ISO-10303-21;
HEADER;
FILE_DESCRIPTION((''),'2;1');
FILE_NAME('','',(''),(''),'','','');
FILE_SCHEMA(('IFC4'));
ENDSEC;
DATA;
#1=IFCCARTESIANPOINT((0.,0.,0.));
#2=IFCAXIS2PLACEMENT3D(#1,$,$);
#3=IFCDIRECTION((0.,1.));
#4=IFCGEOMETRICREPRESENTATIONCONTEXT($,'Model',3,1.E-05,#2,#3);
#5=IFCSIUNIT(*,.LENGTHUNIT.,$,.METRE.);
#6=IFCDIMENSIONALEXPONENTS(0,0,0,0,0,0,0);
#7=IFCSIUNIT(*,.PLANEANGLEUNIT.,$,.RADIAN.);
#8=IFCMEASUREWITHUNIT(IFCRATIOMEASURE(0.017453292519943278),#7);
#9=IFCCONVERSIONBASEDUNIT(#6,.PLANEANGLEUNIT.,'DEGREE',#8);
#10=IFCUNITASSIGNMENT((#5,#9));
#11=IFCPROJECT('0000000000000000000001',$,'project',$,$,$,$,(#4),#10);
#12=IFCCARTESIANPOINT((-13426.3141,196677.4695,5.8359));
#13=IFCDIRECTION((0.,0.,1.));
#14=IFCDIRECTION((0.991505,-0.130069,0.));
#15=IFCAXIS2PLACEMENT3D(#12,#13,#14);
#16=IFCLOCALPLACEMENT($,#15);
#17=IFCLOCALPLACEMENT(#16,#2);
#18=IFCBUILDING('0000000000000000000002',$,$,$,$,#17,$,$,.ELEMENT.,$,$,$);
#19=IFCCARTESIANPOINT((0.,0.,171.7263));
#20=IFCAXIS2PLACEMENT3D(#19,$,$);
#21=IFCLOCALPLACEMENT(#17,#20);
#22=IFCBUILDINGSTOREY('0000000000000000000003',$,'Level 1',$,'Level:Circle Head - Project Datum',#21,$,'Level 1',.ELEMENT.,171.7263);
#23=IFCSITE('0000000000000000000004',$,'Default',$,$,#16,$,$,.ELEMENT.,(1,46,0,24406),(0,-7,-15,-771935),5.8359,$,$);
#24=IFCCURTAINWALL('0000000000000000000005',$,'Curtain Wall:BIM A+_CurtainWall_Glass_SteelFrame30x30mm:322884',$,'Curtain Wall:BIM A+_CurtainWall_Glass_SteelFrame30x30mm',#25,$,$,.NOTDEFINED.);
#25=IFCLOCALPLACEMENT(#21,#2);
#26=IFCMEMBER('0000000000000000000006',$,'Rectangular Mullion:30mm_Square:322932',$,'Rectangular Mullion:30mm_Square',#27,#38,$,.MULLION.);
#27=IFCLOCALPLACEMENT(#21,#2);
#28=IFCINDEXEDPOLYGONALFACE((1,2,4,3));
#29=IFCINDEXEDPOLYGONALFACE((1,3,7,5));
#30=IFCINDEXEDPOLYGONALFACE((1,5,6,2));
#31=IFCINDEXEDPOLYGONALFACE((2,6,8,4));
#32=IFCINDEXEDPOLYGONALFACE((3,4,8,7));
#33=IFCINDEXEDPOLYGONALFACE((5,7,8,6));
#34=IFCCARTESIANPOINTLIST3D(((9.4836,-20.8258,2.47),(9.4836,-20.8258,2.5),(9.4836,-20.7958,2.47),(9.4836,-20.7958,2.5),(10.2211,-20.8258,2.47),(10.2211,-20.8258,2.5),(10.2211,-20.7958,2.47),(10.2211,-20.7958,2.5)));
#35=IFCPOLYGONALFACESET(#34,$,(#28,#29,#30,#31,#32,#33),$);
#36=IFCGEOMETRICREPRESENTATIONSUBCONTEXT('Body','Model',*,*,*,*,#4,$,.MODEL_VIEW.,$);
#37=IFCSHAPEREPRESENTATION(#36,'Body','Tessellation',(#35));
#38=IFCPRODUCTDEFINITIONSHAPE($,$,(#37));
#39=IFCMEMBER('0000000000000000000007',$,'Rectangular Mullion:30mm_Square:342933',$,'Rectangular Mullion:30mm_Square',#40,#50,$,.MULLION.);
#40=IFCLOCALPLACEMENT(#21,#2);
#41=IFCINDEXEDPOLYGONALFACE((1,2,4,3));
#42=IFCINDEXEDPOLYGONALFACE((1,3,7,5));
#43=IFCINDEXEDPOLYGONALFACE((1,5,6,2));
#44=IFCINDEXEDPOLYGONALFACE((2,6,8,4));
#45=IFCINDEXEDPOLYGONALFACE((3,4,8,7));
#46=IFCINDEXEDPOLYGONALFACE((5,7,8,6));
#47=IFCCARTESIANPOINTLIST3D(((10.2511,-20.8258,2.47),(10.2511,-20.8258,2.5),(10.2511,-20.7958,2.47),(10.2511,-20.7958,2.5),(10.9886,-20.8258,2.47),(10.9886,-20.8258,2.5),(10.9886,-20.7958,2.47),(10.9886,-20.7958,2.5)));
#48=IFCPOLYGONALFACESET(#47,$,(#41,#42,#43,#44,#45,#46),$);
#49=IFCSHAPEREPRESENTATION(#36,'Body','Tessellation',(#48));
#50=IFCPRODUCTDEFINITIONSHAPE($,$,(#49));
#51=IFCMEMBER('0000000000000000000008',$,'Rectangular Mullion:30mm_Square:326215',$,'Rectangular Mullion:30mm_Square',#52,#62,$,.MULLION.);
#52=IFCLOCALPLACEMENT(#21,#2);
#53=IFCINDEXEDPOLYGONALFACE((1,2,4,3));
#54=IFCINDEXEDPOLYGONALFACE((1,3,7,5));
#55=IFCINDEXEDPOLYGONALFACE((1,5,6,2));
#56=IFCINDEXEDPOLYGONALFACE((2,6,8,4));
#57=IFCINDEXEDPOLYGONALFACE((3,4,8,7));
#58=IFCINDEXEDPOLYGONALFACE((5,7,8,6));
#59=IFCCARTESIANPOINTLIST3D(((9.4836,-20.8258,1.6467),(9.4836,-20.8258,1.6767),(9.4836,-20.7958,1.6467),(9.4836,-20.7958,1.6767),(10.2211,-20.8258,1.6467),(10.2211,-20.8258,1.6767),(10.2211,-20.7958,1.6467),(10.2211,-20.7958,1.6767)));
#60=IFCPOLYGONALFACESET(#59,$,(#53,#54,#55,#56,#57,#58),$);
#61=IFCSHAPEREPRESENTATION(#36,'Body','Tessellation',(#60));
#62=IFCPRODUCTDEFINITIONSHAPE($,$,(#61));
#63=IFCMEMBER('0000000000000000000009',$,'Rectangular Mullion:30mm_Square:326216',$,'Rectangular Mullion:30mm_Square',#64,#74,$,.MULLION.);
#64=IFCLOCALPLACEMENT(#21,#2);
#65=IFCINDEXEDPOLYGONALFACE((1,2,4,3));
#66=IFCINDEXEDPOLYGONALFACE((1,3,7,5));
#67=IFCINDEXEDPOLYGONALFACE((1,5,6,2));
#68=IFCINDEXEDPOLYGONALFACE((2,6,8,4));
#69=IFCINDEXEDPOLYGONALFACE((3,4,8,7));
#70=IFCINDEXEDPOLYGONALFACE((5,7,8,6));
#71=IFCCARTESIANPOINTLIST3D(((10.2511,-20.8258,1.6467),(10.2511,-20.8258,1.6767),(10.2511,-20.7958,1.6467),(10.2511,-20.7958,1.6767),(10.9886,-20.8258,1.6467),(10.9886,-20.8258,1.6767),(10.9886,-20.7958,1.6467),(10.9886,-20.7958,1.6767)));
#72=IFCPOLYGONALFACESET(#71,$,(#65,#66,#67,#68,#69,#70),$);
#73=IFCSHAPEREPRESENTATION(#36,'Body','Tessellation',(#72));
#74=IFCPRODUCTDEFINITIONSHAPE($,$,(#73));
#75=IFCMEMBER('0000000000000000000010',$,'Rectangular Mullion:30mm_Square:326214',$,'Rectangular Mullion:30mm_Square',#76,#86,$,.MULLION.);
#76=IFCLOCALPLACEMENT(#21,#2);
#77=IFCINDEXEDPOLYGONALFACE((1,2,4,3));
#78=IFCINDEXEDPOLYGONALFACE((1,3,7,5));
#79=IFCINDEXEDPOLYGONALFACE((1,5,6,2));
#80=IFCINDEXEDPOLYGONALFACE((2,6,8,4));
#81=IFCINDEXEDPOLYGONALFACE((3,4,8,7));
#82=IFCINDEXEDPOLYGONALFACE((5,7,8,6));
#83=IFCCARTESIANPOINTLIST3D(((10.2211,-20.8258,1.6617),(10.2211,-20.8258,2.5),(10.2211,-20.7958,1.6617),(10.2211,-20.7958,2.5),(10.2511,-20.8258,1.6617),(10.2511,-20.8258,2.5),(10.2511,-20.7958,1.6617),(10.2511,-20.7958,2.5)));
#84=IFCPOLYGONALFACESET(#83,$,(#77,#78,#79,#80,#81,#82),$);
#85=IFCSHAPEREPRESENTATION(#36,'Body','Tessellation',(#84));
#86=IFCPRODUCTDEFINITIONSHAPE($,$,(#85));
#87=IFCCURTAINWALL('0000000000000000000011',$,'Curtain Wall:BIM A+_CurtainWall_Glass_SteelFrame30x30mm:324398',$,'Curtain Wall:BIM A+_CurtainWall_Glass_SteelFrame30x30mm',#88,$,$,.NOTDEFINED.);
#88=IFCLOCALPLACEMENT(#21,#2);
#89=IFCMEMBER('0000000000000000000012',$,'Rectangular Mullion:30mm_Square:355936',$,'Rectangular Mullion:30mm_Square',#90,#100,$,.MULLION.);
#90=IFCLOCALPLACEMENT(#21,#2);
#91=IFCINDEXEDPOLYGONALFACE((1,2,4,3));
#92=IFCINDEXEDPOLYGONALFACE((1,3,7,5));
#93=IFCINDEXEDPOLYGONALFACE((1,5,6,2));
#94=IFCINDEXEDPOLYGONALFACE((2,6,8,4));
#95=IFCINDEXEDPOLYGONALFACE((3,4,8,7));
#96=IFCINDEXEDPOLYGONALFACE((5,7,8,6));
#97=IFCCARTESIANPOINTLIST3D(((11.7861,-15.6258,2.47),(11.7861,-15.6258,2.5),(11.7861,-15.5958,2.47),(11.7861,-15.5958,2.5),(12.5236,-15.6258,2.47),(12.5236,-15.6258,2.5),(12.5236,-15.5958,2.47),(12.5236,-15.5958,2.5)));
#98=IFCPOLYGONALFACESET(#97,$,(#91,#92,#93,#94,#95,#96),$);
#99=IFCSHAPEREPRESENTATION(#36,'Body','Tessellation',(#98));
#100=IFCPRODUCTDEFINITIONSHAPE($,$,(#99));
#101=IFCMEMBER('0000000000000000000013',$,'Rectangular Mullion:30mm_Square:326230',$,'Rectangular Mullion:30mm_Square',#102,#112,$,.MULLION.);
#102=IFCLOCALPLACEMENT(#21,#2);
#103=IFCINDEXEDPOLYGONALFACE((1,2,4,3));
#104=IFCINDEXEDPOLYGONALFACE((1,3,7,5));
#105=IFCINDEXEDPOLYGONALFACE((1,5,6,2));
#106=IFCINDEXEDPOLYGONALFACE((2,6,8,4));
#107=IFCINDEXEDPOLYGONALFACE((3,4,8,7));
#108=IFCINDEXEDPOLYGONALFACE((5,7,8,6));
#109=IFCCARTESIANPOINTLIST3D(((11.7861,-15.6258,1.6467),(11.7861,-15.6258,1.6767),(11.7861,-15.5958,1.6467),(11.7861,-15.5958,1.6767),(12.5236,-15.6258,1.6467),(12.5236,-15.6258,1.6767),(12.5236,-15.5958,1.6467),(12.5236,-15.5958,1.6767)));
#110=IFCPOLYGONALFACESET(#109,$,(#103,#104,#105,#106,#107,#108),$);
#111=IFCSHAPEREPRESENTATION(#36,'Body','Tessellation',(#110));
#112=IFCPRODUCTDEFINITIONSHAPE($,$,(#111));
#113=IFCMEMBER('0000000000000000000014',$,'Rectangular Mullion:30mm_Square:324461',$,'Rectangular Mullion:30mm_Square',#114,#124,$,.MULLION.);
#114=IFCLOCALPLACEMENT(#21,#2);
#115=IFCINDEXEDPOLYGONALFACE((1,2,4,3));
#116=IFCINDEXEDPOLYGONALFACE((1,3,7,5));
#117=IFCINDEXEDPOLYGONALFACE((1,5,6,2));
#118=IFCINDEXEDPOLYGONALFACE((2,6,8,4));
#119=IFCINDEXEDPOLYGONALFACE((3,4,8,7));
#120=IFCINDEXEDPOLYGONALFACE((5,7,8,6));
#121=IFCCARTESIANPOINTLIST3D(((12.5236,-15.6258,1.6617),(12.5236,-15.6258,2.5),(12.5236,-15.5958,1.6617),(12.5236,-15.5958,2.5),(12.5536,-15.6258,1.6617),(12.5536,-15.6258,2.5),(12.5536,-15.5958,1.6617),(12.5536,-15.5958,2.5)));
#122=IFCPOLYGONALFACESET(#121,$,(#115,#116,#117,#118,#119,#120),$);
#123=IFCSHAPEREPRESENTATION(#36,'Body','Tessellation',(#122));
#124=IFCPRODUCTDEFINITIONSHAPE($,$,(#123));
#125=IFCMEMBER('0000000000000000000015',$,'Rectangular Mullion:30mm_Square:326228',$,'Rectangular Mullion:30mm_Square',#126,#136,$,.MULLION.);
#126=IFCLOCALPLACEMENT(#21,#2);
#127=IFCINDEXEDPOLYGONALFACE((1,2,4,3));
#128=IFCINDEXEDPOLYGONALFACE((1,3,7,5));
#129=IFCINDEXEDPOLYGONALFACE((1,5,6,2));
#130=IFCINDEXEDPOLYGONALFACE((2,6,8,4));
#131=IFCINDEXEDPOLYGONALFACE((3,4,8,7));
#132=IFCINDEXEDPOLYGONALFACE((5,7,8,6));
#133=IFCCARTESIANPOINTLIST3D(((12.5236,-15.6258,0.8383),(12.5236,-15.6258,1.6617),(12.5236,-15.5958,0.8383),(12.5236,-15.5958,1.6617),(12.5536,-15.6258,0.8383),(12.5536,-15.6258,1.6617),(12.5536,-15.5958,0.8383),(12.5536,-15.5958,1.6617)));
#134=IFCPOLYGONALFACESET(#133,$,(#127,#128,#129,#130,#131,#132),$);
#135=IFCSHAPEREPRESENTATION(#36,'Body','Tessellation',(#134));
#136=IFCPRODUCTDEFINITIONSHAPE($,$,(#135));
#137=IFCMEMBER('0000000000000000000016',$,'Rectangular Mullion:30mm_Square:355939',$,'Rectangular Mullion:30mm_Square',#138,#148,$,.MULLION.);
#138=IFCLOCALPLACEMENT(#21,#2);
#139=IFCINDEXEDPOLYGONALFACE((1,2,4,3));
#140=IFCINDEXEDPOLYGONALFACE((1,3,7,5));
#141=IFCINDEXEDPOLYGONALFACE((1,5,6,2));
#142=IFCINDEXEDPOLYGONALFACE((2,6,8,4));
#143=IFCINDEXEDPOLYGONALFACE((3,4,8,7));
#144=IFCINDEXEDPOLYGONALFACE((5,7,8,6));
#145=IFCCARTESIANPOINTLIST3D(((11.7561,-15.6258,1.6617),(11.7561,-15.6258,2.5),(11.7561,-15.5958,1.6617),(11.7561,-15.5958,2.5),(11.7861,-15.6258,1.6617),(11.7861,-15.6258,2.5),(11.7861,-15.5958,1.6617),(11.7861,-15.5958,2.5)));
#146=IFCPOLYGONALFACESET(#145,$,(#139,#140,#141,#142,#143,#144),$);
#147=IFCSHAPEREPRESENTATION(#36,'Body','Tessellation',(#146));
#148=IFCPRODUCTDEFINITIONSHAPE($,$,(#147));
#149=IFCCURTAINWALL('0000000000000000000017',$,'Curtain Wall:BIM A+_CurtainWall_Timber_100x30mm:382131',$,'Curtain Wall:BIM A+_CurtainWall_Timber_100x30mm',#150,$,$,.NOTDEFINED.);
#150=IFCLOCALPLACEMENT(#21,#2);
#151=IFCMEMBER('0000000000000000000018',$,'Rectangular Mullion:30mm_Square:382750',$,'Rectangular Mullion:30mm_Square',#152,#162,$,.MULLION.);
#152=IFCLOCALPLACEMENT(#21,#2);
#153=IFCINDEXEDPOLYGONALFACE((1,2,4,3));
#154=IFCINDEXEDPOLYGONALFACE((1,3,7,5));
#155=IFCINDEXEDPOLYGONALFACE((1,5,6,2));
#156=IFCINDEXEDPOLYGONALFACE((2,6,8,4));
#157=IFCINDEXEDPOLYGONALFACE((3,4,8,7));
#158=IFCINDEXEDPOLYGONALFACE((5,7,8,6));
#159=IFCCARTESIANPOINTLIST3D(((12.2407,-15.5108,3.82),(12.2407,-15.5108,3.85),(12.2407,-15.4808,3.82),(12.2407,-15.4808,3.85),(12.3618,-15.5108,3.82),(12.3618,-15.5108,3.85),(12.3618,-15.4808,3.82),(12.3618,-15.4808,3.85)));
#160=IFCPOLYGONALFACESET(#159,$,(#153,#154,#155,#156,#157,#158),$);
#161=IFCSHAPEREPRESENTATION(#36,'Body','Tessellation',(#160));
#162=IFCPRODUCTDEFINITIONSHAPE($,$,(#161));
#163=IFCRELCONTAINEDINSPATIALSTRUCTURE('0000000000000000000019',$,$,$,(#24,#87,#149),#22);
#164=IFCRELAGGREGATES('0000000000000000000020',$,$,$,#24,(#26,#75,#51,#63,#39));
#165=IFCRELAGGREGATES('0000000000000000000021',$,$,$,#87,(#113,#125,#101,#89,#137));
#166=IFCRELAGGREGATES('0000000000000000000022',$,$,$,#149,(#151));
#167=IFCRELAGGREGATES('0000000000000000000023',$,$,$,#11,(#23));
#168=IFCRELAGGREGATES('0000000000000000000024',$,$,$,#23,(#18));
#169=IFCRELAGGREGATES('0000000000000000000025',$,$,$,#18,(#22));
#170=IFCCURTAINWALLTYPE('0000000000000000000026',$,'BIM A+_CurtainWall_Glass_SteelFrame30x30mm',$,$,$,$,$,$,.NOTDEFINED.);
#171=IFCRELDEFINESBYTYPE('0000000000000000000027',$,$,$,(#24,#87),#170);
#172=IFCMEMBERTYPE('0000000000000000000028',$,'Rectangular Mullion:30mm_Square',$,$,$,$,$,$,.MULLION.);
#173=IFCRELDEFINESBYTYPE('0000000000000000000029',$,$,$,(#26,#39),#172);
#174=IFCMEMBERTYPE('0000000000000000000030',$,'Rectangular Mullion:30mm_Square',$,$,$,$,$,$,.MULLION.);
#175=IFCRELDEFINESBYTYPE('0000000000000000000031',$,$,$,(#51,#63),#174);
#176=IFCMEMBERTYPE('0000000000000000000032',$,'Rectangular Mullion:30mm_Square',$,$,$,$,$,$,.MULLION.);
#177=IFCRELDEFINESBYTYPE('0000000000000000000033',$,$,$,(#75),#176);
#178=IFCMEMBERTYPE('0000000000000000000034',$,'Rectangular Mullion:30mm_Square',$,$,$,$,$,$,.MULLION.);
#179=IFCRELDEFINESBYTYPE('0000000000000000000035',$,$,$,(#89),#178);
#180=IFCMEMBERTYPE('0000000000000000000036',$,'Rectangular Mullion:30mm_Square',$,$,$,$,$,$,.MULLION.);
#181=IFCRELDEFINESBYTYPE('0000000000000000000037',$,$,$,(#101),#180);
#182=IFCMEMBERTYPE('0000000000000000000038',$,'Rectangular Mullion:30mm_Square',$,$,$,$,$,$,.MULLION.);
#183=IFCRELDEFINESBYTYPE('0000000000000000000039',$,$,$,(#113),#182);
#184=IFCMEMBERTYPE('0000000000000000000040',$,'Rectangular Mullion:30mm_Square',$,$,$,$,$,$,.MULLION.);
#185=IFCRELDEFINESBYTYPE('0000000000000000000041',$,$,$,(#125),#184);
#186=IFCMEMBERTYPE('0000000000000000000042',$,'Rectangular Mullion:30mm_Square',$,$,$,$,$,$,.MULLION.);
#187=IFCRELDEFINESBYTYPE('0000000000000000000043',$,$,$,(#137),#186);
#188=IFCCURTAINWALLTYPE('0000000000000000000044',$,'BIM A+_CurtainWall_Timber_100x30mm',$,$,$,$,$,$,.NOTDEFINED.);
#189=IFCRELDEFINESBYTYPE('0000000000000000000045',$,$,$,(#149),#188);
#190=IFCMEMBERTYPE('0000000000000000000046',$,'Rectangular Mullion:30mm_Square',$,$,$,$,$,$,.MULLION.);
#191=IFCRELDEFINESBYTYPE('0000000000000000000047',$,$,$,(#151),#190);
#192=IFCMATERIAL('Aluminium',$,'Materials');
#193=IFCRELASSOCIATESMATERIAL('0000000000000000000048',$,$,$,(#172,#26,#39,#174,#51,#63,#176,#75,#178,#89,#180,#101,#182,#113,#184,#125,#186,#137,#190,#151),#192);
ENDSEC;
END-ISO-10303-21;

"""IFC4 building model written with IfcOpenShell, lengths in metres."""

from ifc_helpers import new_model, entity, si_unit, converted_unit, direction, frame, origin, place, context, subcontext, project, spatial, indexed_curve, outline, extrude, source, transform, mapped, material, type_object, type_shapes, element, aggregate, save


model = new_model("IFC4")

# Units and contexts
model_context = context("Model", 3, precision=1e-05, world=origin(), true_north=direction((0.0, 1.0)))
body_context = subcontext(model_context, "Body", "Model", "MODEL_VIEW")
ifc_project = project(units=[si_unit("LENGTHUNIT", "METRE"), converted_unit("PLANEANGLEUNIT", "DEGREE", entity("IfcRatioMeasure", 0.017453292519943278), si_unit("PLANEANGLEUNIT", "RADIAN"), dimensions=[0, 0, 0, 0, 0, 0, 0])], contexts=[model_context])

# Site, building, storey
site_placement = place(None, frame((-13426.3141, 196677.4695, 5.8359), z_axis=(0.0, 0.0, 1.0), x_axis=(0.991505, -0.130069, 0.0)))
site = spatial("IfcSite", under=ifc_project, at=site_placement, Name="Default", CompositionType="ELEMENT", RefLatitude=(1, 46, 0, 24406), RefLongitude=(0, -7, -15, -771935), RefElevation=5.8359)
building_placement = place(site_placement, origin())
building = spatial("IfcBuilding", under=site, at=building_placement, CompositionType="ELEMENT")
storey_placement = place(building_placement, frame((0.0, 0.0, 171.7263)))
storey = spatial("IfcBuildingStorey", under=building, at=storey_placement, Name="Level 1", ObjectType="Level:Circle Head - Project Datum", LongName="Level 1", CompositionType="ELEMENT", Elevation=171.7263)

# Curtain walls, members
curtain_wall_type_1 = type_object("IfcCurtainWallType", Name="BIM A+_CurtainWall_Glass_SteelFrame30x30mm", PredefinedType="NOTDEFINED")
curtain_wall_1_placement = place(storey_placement, frame((0.0, 0.0, -171.7263)))
curtain_wall_1 = element("IfcCurtainWall", 1, at=curtain_wall_1_placement, inside=storey, type_object=curtain_wall_type_1, Name="Curtain Wall:BIM A+_CurtainWall_Glass_SteelFrame30x30mm:322884", ObjectType="Curtain Wall:BIM A+_CurtainWall_Glass_SteelFrame30x30mm", PredefinedType="NOTDEFINED")
ifc_material_1 = material(Name="Aluminium", Category="Materials")
member_type_1 = type_object("IfcMemberType", Name="Rectangular Mullion:30mm_Square", PredefinedType="MULLION", material=ifc_material_1)
shared_shape_1 = source(origin(), body_context, "Body", "SweptSolid", [
    extrude(outline(indexed_curve([(-0.015, -0.015), (0.015, -0.015), (0.015, 0.015), (-0.015, 0.015), (-0.015, -0.015)], self_intersect=False)), frame((-0.015, 0.0, -0.7375), z_axis=(0.0, 0.0, 1.0), x_axis=(0.0, -1.0, 0.0)), (0.0, 0.0, 1.0), 0.7375),
])
type_shapes(member_type_1, [shared_shape_1])
member_1_placement = place(curtain_wall_1_placement, frame((10.2211, -20.8108, 174.2263), z_axis=(1.0, 0.0, 0.0), x_axis=(0.0, 0.0, 1.0)))
member_1 = element("IfcMember", 2, at=member_1_placement, type_object=member_type_1, material=ifc_material_1, Name="Rectangular Mullion:30mm_Square:322932", ObjectType="Rectangular Mullion:30mm_Square", PredefinedType="MULLION", context=body_context, shape_type="MappedRepresentation", body=[
    mapped(shared_shape_1, transform((0.0, 0.0, 0.0), scale=1.0)),
])
member_2_placement = place(curtain_wall_1_placement, frame((10.9886, -20.8108, 174.2263), z_axis=(1.0, 0.0, 0.0), x_axis=(0.0, 0.0, 1.0)))
member_2 = element("IfcMember", 3, at=member_2_placement, type_object=member_type_1, material=ifc_material_1, Name="Rectangular Mullion:30mm_Square:342933", ObjectType="Rectangular Mullion:30mm_Square", PredefinedType="MULLION", context=body_context, shape_type="MappedRepresentation", body=[
    mapped(shared_shape_1, transform((0.0, 0.0, 0.0), scale=1.0)),
])
member_type_2 = type_object("IfcMemberType", Name="Rectangular Mullion:30mm_Square", PredefinedType="MULLION", material=ifc_material_1)
shared_shape_2 = source(origin(), body_context, "Body", "SweptSolid", [
    extrude(outline(indexed_curve([(-0.015, -0.015), (0.015, -0.015), (0.015, 0.015), (-0.015, 0.015), (-0.015, -0.015)], self_intersect=False)), frame((0.0, 0.0, -0.7375), z_axis=(0.0, 0.0, 1.0), x_axis=(0.0, -1.0, 0.0)), (0.0, 0.0, 1.0), 0.7375),
])
type_shapes(member_type_2, [shared_shape_2])
member_3_placement = place(curtain_wall_1_placement, frame((10.2211, -20.8108, 173.3879), z_axis=(1.0, 0.0, 0.0), x_axis=(0.0, 0.0, 1.0)))
member_3 = element("IfcMember", 4, at=member_3_placement, type_object=member_type_2, material=ifc_material_1, Name="Rectangular Mullion:30mm_Square:326215", ObjectType="Rectangular Mullion:30mm_Square", PredefinedType="MULLION", context=body_context, shape_type="MappedRepresentation", body=[
    mapped(shared_shape_2, transform((0.0, 0.0, 0.0), scale=1.0)),
])
member_4_placement = place(curtain_wall_1_placement, frame((10.9886, -20.8108, 173.3879), z_axis=(1.0, 0.0, 0.0), x_axis=(0.0, 0.0, 1.0)))
member_4 = element("IfcMember", 5, at=member_4_placement, type_object=member_type_2, material=ifc_material_1, Name="Rectangular Mullion:30mm_Square:326216", ObjectType="Rectangular Mullion:30mm_Square", PredefinedType="MULLION", context=body_context, shape_type="MappedRepresentation", body=[
    mapped(shared_shape_2, transform((0.0, 0.0, 0.0), scale=1.0)),
])
member_type_3 = type_object("IfcMemberType", Name="Rectangular Mullion:30mm_Square", PredefinedType="MULLION", material=ifc_material_1)
shared_shape_3 = source(origin(), body_context, "Body", "SweptSolid", [
    extrude(outline(indexed_curve([(-0.015, -0.015), (0.015, -0.015), (0.015, 0.015), (-0.015, 0.015), (-0.015, -0.015)], self_intersect=False)), frame((0.0, 0.0, -0.8383), z_axis=(0.0, 0.0, 1.0), x_axis=(0.0, -1.0, 0.0)), (0.0, 0.0, 1.0), 0.8383),
])
type_shapes(member_type_3, [shared_shape_3])
member_5_placement = place(curtain_wall_1_placement, frame((10.2361, -20.8108, 173.3879), z_axis=(0.0, 0.0, -1.0), x_axis=(1.0, 0.0, 0.0)))
member_5 = element("IfcMember", 6, at=member_5_placement, type_object=member_type_3, material=ifc_material_1, Name="Rectangular Mullion:30mm_Square:326214", ObjectType="Rectangular Mullion:30mm_Square", PredefinedType="MULLION", context=body_context, shape_type="MappedRepresentation", body=[
    mapped(shared_shape_3, transform((0.0, 0.0, 0.0), scale=1.0)),
])
curtain_wall_2_placement = place(storey_placement, frame((0.0, 0.0, -171.7263)))
curtain_wall_2 = element("IfcCurtainWall", 7, at=curtain_wall_2_placement, inside=storey, type_object=curtain_wall_type_1, Name="Curtain Wall:BIM A+_CurtainWall_Glass_SteelFrame30x30mm:324398", ObjectType="Curtain Wall:BIM A+_CurtainWall_Glass_SteelFrame30x30mm", PredefinedType="NOTDEFINED")
member_type_4 = type_object("IfcMemberType", Name="Rectangular Mullion:30mm_Square", PredefinedType="MULLION", material=ifc_material_1)
shared_shape_4 = source(origin(), body_context, "Body", "SweptSolid", [
    extrude(outline(indexed_curve([(-0.015, -0.015), (0.015, -0.015), (0.015, 0.015), (-0.015, 0.015), (-0.015, -0.015)], self_intersect=False)), frame((-0.015, 0.0, -0.7375), z_axis=(0.0, 0.0, 1.0), x_axis=(0.0, -1.0, 0.0)), (0.0, 0.0, 1.0), 0.7375),
])
type_shapes(member_type_4, [shared_shape_4])
member_6_placement = place(curtain_wall_2_placement, frame((11.7861, -15.6108, 174.2263), z_axis=(-1.0, 0.0, 0.0), x_axis=(0.0, 0.0, 1.0)))
member_6 = element("IfcMember", 8, at=member_6_placement, type_object=member_type_4, material=ifc_material_1, Name="Rectangular Mullion:30mm_Square:355936", ObjectType="Rectangular Mullion:30mm_Square", PredefinedType="MULLION", context=body_context, shape_type="MappedRepresentation", body=[
    mapped(shared_shape_4, transform((0.0, 0.0, 0.0), scale=1.0)),
])
member_type_5 = type_object("IfcMemberType", Name="Rectangular Mullion:30mm_Square", PredefinedType="MULLION", material=ifc_material_1)
shared_shape_5 = source(origin(), body_context, "Body", "SweptSolid", [
    extrude(outline(indexed_curve([(-0.015, -0.015), (0.015, -0.015), (0.015, 0.015), (-0.015, 0.015), (-0.015, -0.015)], self_intersect=False)), frame((0.0, 0.0, -0.7375), z_axis=(0.0, 0.0, 1.0), x_axis=(0.0, -1.0, 0.0)), (0.0, 0.0, 1.0), 0.7375),
])
type_shapes(member_type_5, [shared_shape_5])
member_7_placement = place(curtain_wall_2_placement, frame((11.7861, -15.6108, 173.3879), z_axis=(-1.0, 0.0, 0.0), x_axis=(0.0, 0.0, 1.0)))
member_7 = element("IfcMember", 9, at=member_7_placement, type_object=member_type_5, material=ifc_material_1, Name="Rectangular Mullion:30mm_Square:326230", ObjectType="Rectangular Mullion:30mm_Square", PredefinedType="MULLION", context=body_context, shape_type="MappedRepresentation", body=[
    mapped(shared_shape_5, transform((0.0, 0.0, 0.0), scale=1.0)),
])
member_type_6 = type_object("IfcMemberType", Name="Rectangular Mullion:30mm_Square", PredefinedType="MULLION", material=ifc_material_1)
shared_shape_6 = source(origin(), body_context, "Body", "SweptSolid", [
    extrude(outline(indexed_curve([(-0.015, -0.015), (0.015, -0.015), (0.015, 0.015), (-0.015, 0.015), (-0.015, -0.015)], self_intersect=False)), frame((-0.015, 0.0, -0.8383), z_axis=(0.0, 0.0, 1.0), x_axis=(0.0, -1.0, 0.0)), (0.0, 0.0, 1.0), 0.8383),
])
type_shapes(member_type_6, [shared_shape_6])
member_8_placement = place(curtain_wall_2_placement, frame((12.5536, -15.6108, 174.2263)))
member_8 = element("IfcMember", 10, at=member_8_placement, type_object=member_type_6, material=ifc_material_1, Name="Rectangular Mullion:30mm_Square:324461", ObjectType="Rectangular Mullion:30mm_Square", PredefinedType="MULLION", context=body_context, shape_type="MappedRepresentation", body=[
    mapped(shared_shape_6, transform((0.0, 0.0, 0.0), scale=1.0)),
])
member_type_7 = type_object("IfcMemberType", Name="Rectangular Mullion:30mm_Square", PredefinedType="MULLION", material=ifc_material_1)
shared_shape_7 = source(origin(), body_context, "Body", "SweptSolid", [
    extrude(outline(indexed_curve([(-0.015, -0.015), (0.015, -0.015), (0.015, 0.015), (-0.015, 0.015), (-0.015, -0.015)], self_intersect=False)), frame((-0.015, 0.0, -0.8233), z_axis=(0.0, 0.0, 1.0), x_axis=(0.0, -1.0, 0.0)), (0.0, 0.0, 1.0), 0.8233),
])
type_shapes(member_type_7, [shared_shape_7])
member_9_placement = place(curtain_wall_2_placement, frame((12.5536, -15.6108, 173.3879)))
member_9 = element("IfcMember", 11, at=member_9_placement, type_object=member_type_7, material=ifc_material_1, Name="Rectangular Mullion:30mm_Square:326228", ObjectType="Rectangular Mullion:30mm_Square", PredefinedType="MULLION", context=body_context, shape_type="MappedRepresentation", body=[
    mapped(shared_shape_7, transform((0.0, 0.0, 0.0), scale=1.0)),
])
member_type_8 = type_object("IfcMemberType", Name="Rectangular Mullion:30mm_Square", PredefinedType="MULLION", material=ifc_material_1)
shared_shape_8 = source(origin(), body_context, "Body", "SweptSolid", [
    extrude(outline(indexed_curve([(-0.015, -0.015), (0.015, -0.015), (0.015, 0.015), (-0.015, 0.015), (-0.015, -0.015)], self_intersect=False)), frame((0.0, 0.0, -0.8383), z_axis=(0.0, 0.0, 1.0), x_axis=(0.0, -1.0, 0.0)), (0.0, 0.0, 1.0), 0.8383),
])
type_shapes(member_type_8, [shared_shape_8])
member_10_placement = place(curtain_wall_2_placement, frame((11.7711, -15.6108, 173.3879), z_axis=(0.0, 0.0, -1.0), x_axis=(-1.0, 0.0, 0.0)))
member_10 = element("IfcMember", 12, at=member_10_placement, type_object=member_type_8, material=ifc_material_1, Name="Rectangular Mullion:30mm_Square:355939", ObjectType="Rectangular Mullion:30mm_Square", PredefinedType="MULLION", context=body_context, shape_type="MappedRepresentation", body=[
    mapped(shared_shape_8, transform((0.0, 0.0, 0.0), scale=1.0)),
])
curtain_wall_type_2 = type_object("IfcCurtainWallType", Name="BIM A+_CurtainWall_Timber_100x30mm", PredefinedType="NOTDEFINED")
curtain_wall_3_placement = place(storey_placement, frame((0.0, 0.0, -171.7263)))
curtain_wall_3 = element("IfcCurtainWall", 13, at=curtain_wall_3_placement, inside=storey, type_object=curtain_wall_type_2, Name="Curtain Wall:BIM A+_CurtainWall_Timber_100x30mm:382131", ObjectType="Curtain Wall:BIM A+_CurtainWall_Timber_100x30mm", PredefinedType="NOTDEFINED")
member_type_9 = type_object("IfcMemberType", Name="Rectangular Mullion:30mm_Square", PredefinedType="MULLION", material=ifc_material_1)
shared_shape_9 = source(origin(), body_context, "Body", "SweptSolid", [
    extrude(outline(indexed_curve([(-0.015, -0.015), (0.015, -0.015), (0.015, 0.015), (-0.015, 0.015), (-0.015, -0.015)], self_intersect=False)), frame((-0.015, 0.0, -0.1212), z_axis=(0.0, 0.0, 1.0), x_axis=(0.0, -1.0, 0.0)), (0.0, 0.0, 1.0), 0.1212),
])
type_shapes(member_type_9, [shared_shape_9])
member_11_placement = place(curtain_wall_3_placement, frame((12.3618, -15.4958, 175.5763), z_axis=(1.0, 0.0, 0.0), x_axis=(0.0, 0.0, 1.0)))
member_11 = element("IfcMember", 14, at=member_11_placement, type_object=member_type_9, material=ifc_material_1, Name="Rectangular Mullion:30mm_Square:382750", ObjectType="Rectangular Mullion:30mm_Square", PredefinedType="MULLION", context=body_context, shape_type="MappedRepresentation", body=[
    mapped(shared_shape_9, transform((0.0, 0.0, 0.0), scale=1.0)),
])

aggregate(curtain_wall_1, [member_1, member_5, member_3, member_4, member_2])
aggregate(curtain_wall_2, [member_8, member_9, member_7, member_6, member_10])
aggregate(curtain_wall_3, [member_11])

save(model, "model.ifc")
